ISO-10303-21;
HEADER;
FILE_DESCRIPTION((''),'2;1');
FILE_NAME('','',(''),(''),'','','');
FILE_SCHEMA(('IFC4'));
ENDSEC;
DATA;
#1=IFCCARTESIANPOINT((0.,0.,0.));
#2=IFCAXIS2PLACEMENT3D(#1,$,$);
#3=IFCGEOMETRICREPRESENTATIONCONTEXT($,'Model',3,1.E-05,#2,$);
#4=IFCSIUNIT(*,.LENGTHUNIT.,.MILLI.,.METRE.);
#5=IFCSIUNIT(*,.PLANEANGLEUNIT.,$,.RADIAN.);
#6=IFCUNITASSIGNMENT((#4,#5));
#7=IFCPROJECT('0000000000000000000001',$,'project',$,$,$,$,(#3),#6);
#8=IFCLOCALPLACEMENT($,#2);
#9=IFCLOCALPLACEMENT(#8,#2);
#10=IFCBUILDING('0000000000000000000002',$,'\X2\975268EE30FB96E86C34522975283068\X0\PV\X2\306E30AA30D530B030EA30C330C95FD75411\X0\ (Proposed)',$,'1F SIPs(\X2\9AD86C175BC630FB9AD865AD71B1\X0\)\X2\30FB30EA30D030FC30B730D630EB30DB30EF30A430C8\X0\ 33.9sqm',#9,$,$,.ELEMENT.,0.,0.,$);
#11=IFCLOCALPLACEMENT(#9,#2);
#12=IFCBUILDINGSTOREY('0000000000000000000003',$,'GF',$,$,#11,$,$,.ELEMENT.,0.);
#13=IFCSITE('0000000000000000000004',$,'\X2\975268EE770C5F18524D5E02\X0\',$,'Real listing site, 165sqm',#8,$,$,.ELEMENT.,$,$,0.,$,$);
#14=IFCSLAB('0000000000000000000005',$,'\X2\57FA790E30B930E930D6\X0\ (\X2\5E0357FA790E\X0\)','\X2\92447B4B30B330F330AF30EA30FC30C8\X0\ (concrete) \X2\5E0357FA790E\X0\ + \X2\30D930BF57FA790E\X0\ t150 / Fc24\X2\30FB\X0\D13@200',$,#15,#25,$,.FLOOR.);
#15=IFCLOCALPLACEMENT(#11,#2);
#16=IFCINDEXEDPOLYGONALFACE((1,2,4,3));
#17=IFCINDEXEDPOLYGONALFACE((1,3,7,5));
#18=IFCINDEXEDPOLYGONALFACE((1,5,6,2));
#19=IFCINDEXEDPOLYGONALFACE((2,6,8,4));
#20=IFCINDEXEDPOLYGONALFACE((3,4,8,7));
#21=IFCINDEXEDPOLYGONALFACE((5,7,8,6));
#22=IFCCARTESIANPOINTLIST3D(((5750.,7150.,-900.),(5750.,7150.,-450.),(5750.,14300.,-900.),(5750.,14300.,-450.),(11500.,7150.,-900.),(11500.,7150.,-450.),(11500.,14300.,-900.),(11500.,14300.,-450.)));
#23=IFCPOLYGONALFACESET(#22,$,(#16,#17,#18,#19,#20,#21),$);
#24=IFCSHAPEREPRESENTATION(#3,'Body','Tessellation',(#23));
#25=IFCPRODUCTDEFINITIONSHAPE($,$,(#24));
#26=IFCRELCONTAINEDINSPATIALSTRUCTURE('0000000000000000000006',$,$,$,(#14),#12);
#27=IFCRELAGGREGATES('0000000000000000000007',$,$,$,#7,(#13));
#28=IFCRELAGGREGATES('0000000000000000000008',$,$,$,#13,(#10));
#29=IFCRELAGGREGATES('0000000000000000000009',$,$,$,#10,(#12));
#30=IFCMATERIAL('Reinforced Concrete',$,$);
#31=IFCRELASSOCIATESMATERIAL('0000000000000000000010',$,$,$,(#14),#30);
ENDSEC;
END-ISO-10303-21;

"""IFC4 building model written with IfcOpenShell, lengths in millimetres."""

from ifc_helpers import new_model, si_unit, frame, frame_2d, origin, place, context, project, spatial, rectangle, extrude, material, element, save


model = new_model("IFC4")

# Units and contexts
model_context = context("Model", 3, precision=1e-05, world=origin())
ifc_project = project(units=[si_unit("LENGTHUNIT", "METRE", prefix="MILLI"), si_unit("PLANEANGLEUNIT", "RADIAN")], contexts=[model_context])

# Site, building, storey
site_placement = place(None, origin())
site = spatial("IfcSite", under=ifc_project, at=site_placement, Name="青森県弘前市", ObjectType="Real listing site, 165sqm", CompositionType="ELEMENT", RefElevation=0.0)
building_placement = place(site_placement, origin())
building = spatial("IfcBuilding", under=site, at=building_placement, Name="青森・雨水利用とPVのオフグリッド志向 (Proposed)", ObjectType="1F SIPs(高気密・高断熱)・リバーシブルホワイト 33.9sqm", CompositionType="ELEMENT", ElevationOfRefHeight=0.0, ElevationOfTerrain=0.0)
storey_placement = place(building_placement, origin())
storey = spatial("IfcBuildingStorey", under=building, at=storey_placement, Name="GF", CompositionType="ELEMENT", Elevation=0.0)

# Slab
ifc_material_1 = material(Name="Reinforced Concrete")
slab_1_placement = place(storey_placement, frame((2875.0, 3575.0, -450.0)))
element("IfcSlab", 1, at=slab_1_placement, inside=storey, material=ifc_material_1, Name="基礎スラブ (布基礎)", Description="鉄筋コンクリート (concrete) 布基礎 + ベタ基礎 t150 / Fc24・D13@200", PredefinedType="FLOOR", context=model_context, shape_type="SweptSolid", body=[
    extrude(rectangle(XDim=5750.0, YDim=7150.0, at=frame_2d((2875.0, 3575.0))), frame((2875.0, 3575.0, -450.0)), (0.0, 0.0, 1.0), 450.0),
])

save(model, "model.ifc")
